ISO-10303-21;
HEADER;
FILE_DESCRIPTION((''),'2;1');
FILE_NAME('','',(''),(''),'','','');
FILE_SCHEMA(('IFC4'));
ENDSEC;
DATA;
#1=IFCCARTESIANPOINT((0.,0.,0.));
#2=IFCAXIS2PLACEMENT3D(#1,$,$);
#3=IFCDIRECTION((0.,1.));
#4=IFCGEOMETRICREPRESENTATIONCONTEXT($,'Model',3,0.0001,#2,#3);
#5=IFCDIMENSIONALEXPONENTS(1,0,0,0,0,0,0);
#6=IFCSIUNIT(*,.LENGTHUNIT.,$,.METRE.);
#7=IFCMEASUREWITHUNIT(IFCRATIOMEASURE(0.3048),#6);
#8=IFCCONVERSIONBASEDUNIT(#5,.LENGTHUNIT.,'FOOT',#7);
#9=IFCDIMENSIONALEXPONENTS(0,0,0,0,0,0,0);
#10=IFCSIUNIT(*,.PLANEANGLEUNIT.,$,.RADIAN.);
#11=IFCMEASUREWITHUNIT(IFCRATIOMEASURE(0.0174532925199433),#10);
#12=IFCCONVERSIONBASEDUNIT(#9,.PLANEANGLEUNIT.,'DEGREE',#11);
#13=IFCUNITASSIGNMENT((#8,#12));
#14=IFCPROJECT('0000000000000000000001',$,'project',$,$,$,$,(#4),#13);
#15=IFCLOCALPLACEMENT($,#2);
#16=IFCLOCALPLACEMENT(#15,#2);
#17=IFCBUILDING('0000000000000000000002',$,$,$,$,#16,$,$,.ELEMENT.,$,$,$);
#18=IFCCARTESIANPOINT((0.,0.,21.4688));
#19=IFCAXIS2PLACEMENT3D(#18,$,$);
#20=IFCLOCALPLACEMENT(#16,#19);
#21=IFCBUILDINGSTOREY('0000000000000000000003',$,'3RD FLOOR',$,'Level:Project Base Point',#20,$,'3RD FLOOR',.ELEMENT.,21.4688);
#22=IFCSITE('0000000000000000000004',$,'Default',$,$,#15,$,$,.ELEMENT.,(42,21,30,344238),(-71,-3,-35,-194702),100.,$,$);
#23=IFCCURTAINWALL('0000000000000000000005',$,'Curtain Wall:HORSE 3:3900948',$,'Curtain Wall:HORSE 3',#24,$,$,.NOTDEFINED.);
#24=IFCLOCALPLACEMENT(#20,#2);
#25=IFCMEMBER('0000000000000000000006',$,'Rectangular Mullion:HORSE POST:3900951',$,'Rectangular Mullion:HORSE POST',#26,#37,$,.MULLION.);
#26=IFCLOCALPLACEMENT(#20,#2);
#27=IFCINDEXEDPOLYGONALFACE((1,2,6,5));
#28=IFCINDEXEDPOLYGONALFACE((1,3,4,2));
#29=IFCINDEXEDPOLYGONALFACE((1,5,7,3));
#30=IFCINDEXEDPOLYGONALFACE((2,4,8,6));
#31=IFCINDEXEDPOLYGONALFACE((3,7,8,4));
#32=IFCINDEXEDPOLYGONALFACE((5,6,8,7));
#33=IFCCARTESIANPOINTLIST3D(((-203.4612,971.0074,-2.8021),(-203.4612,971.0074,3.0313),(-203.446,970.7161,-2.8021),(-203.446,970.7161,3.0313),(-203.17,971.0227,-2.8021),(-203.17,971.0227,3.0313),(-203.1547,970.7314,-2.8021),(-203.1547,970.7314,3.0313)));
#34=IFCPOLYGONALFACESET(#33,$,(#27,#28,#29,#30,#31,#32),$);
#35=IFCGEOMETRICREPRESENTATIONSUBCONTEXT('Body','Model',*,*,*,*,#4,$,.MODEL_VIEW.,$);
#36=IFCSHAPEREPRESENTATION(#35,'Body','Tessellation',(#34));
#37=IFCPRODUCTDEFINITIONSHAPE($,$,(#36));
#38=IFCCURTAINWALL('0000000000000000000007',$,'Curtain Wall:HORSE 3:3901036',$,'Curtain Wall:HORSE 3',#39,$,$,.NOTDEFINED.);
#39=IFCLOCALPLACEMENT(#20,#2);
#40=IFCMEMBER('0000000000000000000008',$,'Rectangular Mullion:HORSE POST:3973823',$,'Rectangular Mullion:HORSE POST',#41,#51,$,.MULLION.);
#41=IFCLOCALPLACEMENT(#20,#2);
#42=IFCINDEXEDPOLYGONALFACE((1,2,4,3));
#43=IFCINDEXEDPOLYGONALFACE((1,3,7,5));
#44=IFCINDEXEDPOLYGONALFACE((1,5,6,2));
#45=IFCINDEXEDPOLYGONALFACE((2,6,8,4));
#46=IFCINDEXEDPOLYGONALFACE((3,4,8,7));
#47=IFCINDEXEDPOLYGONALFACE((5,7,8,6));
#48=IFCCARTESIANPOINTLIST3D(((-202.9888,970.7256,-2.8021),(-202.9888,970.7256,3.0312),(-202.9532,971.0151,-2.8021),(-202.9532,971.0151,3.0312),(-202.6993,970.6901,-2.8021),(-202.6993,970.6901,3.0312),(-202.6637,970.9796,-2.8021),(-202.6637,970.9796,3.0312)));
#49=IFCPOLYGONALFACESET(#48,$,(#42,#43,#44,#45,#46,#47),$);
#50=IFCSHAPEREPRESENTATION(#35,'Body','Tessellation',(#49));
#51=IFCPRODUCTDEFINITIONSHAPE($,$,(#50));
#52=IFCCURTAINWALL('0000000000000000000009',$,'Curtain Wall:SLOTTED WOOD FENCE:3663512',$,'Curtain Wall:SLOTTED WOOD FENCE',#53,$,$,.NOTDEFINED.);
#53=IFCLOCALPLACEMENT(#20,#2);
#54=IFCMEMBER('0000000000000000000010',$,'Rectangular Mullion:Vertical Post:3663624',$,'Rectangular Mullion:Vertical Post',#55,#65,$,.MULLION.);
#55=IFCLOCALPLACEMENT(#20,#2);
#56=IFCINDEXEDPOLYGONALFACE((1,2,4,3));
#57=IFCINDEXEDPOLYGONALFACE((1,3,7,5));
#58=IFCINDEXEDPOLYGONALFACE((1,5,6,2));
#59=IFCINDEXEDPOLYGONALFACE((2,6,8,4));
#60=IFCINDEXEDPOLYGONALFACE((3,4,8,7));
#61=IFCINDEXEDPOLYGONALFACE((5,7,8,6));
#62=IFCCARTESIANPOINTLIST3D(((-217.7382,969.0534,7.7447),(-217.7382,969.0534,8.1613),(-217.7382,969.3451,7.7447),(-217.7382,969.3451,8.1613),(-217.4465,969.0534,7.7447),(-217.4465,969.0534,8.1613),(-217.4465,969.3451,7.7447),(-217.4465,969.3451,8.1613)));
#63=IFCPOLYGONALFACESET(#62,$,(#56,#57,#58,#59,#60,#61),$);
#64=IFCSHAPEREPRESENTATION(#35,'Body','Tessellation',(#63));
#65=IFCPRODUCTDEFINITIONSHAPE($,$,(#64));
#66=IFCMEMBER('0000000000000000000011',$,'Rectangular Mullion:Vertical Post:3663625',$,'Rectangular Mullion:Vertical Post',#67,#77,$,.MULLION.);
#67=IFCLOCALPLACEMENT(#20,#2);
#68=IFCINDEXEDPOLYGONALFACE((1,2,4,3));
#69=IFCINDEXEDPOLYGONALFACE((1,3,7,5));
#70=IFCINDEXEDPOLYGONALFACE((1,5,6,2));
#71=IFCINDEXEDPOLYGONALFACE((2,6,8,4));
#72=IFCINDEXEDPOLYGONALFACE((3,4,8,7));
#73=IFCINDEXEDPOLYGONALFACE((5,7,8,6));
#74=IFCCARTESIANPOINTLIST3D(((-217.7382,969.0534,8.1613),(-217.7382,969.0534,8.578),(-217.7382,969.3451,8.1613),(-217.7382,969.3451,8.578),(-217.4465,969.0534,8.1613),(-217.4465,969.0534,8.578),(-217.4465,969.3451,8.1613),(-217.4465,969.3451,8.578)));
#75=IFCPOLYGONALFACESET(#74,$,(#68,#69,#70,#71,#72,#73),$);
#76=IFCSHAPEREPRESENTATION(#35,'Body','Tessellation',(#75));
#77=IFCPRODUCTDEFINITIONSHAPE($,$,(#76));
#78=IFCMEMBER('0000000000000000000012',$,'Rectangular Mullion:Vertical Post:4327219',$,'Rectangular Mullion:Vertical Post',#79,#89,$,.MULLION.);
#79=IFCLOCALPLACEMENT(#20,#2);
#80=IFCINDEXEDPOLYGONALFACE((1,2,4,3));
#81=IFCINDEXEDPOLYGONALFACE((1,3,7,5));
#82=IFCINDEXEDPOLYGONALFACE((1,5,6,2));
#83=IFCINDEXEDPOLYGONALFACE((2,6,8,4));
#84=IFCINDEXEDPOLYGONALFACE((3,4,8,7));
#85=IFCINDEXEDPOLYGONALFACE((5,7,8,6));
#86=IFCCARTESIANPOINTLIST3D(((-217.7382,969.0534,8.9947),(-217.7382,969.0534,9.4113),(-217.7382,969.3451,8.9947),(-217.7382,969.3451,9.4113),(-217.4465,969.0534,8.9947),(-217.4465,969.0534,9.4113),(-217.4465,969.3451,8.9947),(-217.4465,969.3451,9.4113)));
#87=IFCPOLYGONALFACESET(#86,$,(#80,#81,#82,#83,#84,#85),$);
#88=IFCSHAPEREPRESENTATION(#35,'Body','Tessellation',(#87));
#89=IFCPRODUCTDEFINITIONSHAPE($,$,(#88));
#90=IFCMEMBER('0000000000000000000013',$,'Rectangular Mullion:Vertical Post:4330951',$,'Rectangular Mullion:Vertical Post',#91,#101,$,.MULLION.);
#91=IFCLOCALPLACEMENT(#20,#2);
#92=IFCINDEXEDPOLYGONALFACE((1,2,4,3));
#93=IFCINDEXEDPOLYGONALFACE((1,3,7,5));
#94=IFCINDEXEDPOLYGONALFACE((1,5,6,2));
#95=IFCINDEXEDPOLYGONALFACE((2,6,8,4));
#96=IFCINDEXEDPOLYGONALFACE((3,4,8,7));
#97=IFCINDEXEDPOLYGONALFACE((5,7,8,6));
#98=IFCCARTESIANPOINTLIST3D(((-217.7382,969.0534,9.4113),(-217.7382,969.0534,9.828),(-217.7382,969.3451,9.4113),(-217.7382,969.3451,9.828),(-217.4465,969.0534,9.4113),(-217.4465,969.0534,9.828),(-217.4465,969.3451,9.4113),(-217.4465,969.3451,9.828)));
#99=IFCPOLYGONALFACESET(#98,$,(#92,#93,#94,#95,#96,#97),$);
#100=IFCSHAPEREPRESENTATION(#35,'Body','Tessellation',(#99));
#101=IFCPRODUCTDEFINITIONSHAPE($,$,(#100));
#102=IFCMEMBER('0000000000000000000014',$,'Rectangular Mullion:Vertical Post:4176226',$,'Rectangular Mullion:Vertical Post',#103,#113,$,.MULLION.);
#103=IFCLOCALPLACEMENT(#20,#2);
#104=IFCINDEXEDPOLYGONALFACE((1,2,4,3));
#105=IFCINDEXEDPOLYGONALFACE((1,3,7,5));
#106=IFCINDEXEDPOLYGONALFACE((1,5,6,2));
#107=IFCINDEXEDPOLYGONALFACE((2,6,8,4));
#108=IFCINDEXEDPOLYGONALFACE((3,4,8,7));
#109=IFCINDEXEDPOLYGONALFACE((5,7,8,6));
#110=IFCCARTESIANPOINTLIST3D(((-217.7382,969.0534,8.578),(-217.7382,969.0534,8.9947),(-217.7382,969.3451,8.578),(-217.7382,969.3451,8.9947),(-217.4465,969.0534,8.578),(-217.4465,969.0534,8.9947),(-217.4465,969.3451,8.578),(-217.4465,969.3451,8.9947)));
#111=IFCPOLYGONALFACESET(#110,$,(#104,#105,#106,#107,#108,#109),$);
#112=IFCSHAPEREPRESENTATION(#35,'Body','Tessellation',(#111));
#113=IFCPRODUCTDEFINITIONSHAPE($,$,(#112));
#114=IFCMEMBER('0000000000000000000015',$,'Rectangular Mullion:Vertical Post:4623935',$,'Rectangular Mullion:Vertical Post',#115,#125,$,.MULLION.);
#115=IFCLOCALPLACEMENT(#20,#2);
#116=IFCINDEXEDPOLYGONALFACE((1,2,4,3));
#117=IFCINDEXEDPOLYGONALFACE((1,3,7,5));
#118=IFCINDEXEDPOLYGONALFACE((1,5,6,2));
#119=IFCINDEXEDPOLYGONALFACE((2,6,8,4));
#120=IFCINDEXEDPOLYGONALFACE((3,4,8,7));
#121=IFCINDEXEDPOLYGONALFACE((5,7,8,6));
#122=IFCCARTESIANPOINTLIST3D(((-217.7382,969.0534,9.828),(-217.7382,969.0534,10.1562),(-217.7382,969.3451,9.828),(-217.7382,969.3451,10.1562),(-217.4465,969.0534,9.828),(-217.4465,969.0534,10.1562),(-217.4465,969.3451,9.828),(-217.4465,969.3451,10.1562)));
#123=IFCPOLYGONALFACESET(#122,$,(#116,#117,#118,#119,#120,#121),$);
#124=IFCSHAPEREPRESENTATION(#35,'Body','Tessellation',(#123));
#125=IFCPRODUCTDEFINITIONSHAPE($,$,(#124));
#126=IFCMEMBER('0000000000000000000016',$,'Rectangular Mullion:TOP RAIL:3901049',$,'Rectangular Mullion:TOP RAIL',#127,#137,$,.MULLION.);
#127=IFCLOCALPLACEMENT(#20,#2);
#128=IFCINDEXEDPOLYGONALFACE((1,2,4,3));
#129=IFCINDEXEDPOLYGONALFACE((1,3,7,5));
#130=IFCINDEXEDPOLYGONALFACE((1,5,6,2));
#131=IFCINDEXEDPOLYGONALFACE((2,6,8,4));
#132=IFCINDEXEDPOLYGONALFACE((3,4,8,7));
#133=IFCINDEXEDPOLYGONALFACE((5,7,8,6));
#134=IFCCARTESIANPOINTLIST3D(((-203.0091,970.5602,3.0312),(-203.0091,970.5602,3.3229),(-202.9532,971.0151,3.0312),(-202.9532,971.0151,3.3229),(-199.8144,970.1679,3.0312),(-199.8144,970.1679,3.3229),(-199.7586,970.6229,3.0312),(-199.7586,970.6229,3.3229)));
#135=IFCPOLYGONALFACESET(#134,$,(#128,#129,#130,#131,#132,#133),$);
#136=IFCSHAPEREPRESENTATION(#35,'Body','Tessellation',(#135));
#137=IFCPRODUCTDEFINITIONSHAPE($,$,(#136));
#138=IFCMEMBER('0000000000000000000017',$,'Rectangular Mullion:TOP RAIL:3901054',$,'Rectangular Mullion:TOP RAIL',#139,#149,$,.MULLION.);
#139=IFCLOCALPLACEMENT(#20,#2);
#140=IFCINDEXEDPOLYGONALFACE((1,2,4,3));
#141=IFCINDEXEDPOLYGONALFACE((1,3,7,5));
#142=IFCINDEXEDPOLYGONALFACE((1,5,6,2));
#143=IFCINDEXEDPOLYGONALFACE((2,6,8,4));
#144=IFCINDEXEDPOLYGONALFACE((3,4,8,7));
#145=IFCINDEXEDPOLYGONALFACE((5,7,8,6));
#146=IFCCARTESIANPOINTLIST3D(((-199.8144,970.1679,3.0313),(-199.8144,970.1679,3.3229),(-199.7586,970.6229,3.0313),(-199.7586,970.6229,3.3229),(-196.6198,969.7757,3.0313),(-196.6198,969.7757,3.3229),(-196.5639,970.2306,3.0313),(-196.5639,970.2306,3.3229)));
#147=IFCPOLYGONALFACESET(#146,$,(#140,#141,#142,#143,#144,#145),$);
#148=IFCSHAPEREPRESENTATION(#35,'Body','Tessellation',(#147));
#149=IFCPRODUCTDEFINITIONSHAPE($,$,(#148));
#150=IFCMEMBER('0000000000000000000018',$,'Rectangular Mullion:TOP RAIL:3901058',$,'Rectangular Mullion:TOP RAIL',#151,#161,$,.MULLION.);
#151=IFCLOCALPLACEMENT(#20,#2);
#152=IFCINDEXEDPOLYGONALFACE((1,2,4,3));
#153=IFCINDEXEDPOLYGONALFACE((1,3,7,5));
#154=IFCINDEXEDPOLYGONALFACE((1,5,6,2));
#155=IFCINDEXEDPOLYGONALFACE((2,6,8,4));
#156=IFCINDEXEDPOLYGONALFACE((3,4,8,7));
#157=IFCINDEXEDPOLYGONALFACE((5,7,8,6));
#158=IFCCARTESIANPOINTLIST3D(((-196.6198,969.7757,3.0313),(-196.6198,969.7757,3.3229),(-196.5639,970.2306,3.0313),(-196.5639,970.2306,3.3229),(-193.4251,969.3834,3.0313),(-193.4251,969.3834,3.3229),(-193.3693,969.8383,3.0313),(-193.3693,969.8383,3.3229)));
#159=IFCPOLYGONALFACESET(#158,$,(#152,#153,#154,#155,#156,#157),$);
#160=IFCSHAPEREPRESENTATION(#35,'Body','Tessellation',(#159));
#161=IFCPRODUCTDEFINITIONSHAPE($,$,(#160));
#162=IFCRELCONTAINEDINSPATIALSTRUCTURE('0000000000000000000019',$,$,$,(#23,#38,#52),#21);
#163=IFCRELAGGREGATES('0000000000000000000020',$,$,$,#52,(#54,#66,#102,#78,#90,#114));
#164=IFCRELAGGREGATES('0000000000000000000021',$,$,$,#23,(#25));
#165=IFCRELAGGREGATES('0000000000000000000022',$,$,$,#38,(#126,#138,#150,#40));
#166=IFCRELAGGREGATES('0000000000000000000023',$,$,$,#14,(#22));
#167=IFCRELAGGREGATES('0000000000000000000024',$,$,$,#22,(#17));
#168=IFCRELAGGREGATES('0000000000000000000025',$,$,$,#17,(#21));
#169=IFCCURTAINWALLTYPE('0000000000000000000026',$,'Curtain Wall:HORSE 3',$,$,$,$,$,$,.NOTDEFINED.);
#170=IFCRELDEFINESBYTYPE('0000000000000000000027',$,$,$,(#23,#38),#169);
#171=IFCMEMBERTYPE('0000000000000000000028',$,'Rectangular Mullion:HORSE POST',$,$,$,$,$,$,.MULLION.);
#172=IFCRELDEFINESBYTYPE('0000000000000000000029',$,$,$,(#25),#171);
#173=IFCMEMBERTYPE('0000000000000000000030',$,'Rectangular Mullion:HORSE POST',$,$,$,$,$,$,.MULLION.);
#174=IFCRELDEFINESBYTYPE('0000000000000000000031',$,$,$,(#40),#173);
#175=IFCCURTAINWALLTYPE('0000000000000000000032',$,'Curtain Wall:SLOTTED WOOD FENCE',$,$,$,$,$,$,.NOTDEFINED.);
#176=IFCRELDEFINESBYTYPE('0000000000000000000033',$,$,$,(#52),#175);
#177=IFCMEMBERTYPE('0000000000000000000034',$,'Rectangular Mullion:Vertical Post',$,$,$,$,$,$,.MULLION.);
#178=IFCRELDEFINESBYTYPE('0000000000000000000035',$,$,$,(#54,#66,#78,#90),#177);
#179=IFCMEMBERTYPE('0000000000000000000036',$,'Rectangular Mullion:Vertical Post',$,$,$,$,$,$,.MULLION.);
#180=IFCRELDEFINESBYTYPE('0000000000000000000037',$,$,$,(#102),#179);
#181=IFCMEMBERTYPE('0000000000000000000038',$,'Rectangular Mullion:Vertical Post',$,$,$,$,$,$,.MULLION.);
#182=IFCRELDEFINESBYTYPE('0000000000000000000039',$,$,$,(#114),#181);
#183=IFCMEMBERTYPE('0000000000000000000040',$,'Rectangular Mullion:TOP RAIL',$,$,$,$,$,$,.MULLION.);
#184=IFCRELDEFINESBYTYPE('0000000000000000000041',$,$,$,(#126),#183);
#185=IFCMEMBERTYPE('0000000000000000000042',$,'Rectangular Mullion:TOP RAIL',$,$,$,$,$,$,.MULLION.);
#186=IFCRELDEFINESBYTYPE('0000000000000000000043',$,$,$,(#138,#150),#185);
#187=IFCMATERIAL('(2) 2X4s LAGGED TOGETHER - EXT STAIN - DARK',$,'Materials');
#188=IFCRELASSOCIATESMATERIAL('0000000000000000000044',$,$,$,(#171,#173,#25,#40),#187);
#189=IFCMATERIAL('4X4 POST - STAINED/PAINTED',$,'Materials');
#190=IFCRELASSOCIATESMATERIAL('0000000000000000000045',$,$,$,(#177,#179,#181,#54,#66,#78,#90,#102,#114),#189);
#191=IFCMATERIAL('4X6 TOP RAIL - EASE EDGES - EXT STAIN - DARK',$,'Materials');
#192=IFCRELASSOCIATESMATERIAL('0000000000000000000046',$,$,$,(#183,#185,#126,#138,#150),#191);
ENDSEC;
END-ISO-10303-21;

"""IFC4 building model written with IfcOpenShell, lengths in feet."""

from ifc_helpers import new_model, entity, si_unit, converted_unit, direction, frame, frame_2d, origin, origin_2d_with_axis, place, context, subcontext, project, spatial, rectangle, extrude, source, transform, mapped, material, material_profile, profile_set, profile_usage, type_object, type_shapes, element, aggregate, save


model = new_model("IFC4")

# Units and contexts
model_context = context("Model", 3, precision=0.0001, world=origin(), true_north=direction((0.0, 1.0)))
body_context = subcontext(model_context, "Body", "Model", "MODEL_VIEW")
ifc_project = project(units=[converted_unit("LENGTHUNIT", "FOOT", entity("IfcRatioMeasure", 0.3048), si_unit("LENGTHUNIT", "METRE"), dimensions=[1, 0, 0, 0, 0, 0, 0]), converted_unit("PLANEANGLEUNIT", "DEGREE", entity("IfcRatioMeasure", 0.0174532925199433), si_unit("PLANEANGLEUNIT", "RADIAN"), dimensions=[0, 0, 0, 0, 0, 0, 0])], contexts=[model_context])

# Site, building, storey
site_placement = place(None, origin())
site = spatial("IfcSite", under=ifc_project, at=site_placement, Name="Default", CompositionType="ELEMENT", RefLatitude=(42, 21, 30, 344238), RefLongitude=(-71, -3, -35, -194702), RefElevation=100.0)
building_placement = place(site_placement, origin())
building = spatial("IfcBuilding", under=site, at=building_placement, CompositionType="ELEMENT")
storey_placement = place(building_placement, frame((0.0, 0.0, 21.4688)))
storey = spatial("IfcBuildingStorey", under=building, at=storey_placement, Name="3RD FLOOR", ObjectType="Level:Project Base Point", LongName="3RD FLOOR", CompositionType="ELEMENT", Elevation=21.4688)

# Curtain walls, members
curtain_wall_type_1 = type_object("IfcCurtainWallType", Name="Curtain Wall:HORSE 3", PredefinedType="NOTDEFINED")
curtain_wall_1_placement = place(storey_placement, frame((0.0, 0.0, -21.4688)))
curtain_wall_1 = element("IfcCurtainWall", 1, at=curtain_wall_1_placement, inside=storey, type_object=curtain_wall_type_1, Name="Curtain Wall:HORSE 3:3900948", ObjectType="Curtain Wall:HORSE 3", PredefinedType="NOTDEFINED")
ifc_material_1 = material(Name="(2) 2X4s LAGGED TOGETHER - EXT STAIN - DARK", Category="Materials")
ifc_material_profile_1 = material_profile(ifc_material_1, rectangle(XDim=0.2917, YDim=0.2917, at=frame_2d((0.0, 0.0), x_axis=(1.0, 0.0))), Name="HORSE POST")
ifc_profile_set_1 = profile_set([ifc_material_profile_1], Name="HORSE POST")
ifc_profile_usage_1 = profile_usage(ifc_profile_set_1)
member_type_1 = type_object("IfcMemberType", Name="Rectangular Mullion:HORSE POST", PredefinedType="MULLION", material=ifc_profile_set_1)
shared_shape_1 = source(origin(), body_context, "Body", "SweptSolid", [
    extrude(rectangle(XDim=0.2917, YDim=0.2917, at=frame_2d((0.0, 0.0), x_axis=(1.0, 0.0))), frame((-0.1458, -0.1458, -5.8333), z_axis=(0.0, 0.0, 1.0), x_axis=(0.0, -1.0, 0.0)), (0.0, 0.0, 1.0), 5.8333),
])
type_shapes(member_type_1, [shared_shape_1])
member_1_placement = place(storey_placement, frame((-203.1547, 970.7314, -2.8021), z_axis=(0.0, 0.0, -1.0), x_axis=(0.99863, 0.052336, 0.0)))
member_1 = element("IfcMember", 2, at=member_1_placement, type_object=member_type_1, material=ifc_profile_usage_1, Name="Rectangular Mullion:HORSE POST:3900951", ObjectType="Rectangular Mullion:HORSE POST", PredefinedType="MULLION", context=body_context, shape_type="MappedRepresentation", body=[
    mapped(shared_shape_1, transform((0.0, 0.0, 0.0), scale=1.0)),
])
curtain_wall_2_placement = place(storey_placement, frame((0.0, 0.0, -21.4688)))
curtain_wall_2 = element("IfcCurtainWall", 3, at=curtain_wall_2_placement, inside=storey, type_object=curtain_wall_type_1, Name="Curtain Wall:HORSE 3:3901036", ObjectType="Curtain Wall:HORSE 3", PredefinedType="NOTDEFINED")
ifc_profile_usage_2 = profile_usage(ifc_profile_set_1)
member_type_2 = type_object("IfcMemberType", Name="Rectangular Mullion:HORSE POST", PredefinedType="MULLION", material=ifc_profile_set_1)
shared_shape_2 = source(origin(), body_context, "Body", "SweptSolid", [
    extrude(rectangle(XDim=0.2917, YDim=0.2917, at=origin_2d_with_axis()), frame((-0.1458, -0.1458, -5.8333), z_axis=(0.0, 0.0, 1.0), x_axis=(0.0, -1.0, 0.0)), (0.0, 0.0, 1.0), 5.8333),
])
type_shapes(member_type_2, [shared_shape_2])
member_2_placement = place(storey_placement, frame((-202.9888, 970.7256, 3.0312), z_axis=(0.0, 0.0, 1.0), x_axis=(-0.992546, 0.121869, 0.0)))
member_2 = element("IfcMember", 4, at=member_2_placement, type_object=member_type_2, material=ifc_profile_usage_2, Name="Rectangular Mullion:HORSE POST:3973823", ObjectType="Rectangular Mullion:HORSE POST", PredefinedType="MULLION", context=body_context, shape_type="MappedRepresentation", body=[
    mapped(shared_shape_2, transform((0.0, 0.0, 0.0), scale=1.0)),
])

# Curtain wall, members
curtain_wall_type_2 = type_object("IfcCurtainWallType", Name="Curtain Wall:SLOTTED WOOD FENCE", PredefinedType="NOTDEFINED")
curtain_wall_3_placement = place(storey_placement, frame((0.0, 0.0, -21.4688)))
curtain_wall_3 = element("IfcCurtainWall", 5, at=curtain_wall_3_placement, inside=storey, type_object=curtain_wall_type_2, Name="Curtain Wall:SLOTTED WOOD FENCE:3663512", ObjectType="Curtain Wall:SLOTTED WOOD FENCE", PredefinedType="NOTDEFINED")
ifc_material_2 = material(Name="4X4 POST - STAINED/PAINTED", Category="Materials")
ifc_material_profile_2 = material_profile(ifc_material_2, rectangle(XDim=0.2917, YDim=0.2917, at=origin_2d_with_axis()), Name="Vertical Post")
ifc_profile_set_2 = profile_set([ifc_material_profile_2], Name="Vertical Post")
ifc_profile_usage_3 = profile_usage(ifc_profile_set_2)
member_type_3 = type_object("IfcMemberType", Name="Rectangular Mullion:Vertical Post", PredefinedType="MULLION", material=ifc_profile_set_2)
shared_shape_3 = source(origin(), body_context, "Body", "SweptSolid", [
    extrude(rectangle(XDim=0.2917, YDim=0.2917, at=origin_2d_with_axis()), frame((-0.1458, -0.2083, -0.4167), z_axis=(0.0, 0.0, 1.0), x_axis=(0.0, -1.0, 0.0)), (0.0, 0.0, 1.0), 0.4167),
])
type_shapes(member_type_3, [shared_shape_3])
member_3_placement = place(storey_placement, frame((-217.8007, 969.3451, 8.1613), z_axis=(0.0, 0.0, 1.0), x_axis=(0.0, 1.0, 0.0)))
member_3 = element("IfcMember", 6, at=member_3_placement, type_object=member_type_3, material=ifc_profile_usage_3, Name="Rectangular Mullion:Vertical Post:3663624", ObjectType="Rectangular Mullion:Vertical Post", PredefinedType="MULLION", context=body_context, shape_type="MappedRepresentation", body=[
    mapped(shared_shape_3, transform((0.0, 0.0, 0.0), scale=1.0)),
])
ifc_profile_usage_4 = profile_usage(ifc_profile_set_2)
member_4_placement = place(storey_placement, frame((-217.8007, 969.3451, 8.578), z_axis=(0.0, 0.0, 1.0), x_axis=(0.0, 1.0, 0.0)))
member_4 = element("IfcMember", 7, at=member_4_placement, type_object=member_type_3, material=ifc_profile_usage_4, Name="Rectangular Mullion:Vertical Post:3663625", ObjectType="Rectangular Mullion:Vertical Post", PredefinedType="MULLION", context=body_context, shape_type="MappedRepresentation", body=[
    mapped(shared_shape_3, transform((0.0, 0.0, 0.0), scale=1.0)),
])
ifc_profile_usage_5 = profile_usage(ifc_profile_set_2)
member_5_placement = place(storey_placement, frame((-217.8007, 969.3451, 9.4113), z_axis=(0.0, 0.0, 1.0), x_axis=(0.0, 1.0, 0.0)))
member_5 = element("IfcMember", 8, at=member_5_placement, type_object=member_type_3, material=ifc_profile_usage_5, Name="Rectangular Mullion:Vertical Post:4327219", ObjectType="Rectangular Mullion:Vertical Post", PredefinedType="MULLION", context=body_context, shape_type="MappedRepresentation", body=[
    mapped(shared_shape_3, transform((0.0, 0.0, 0.0), scale=1.0)),
])
ifc_profile_usage_6 = profile_usage(ifc_profile_set_2)
member_6_placement = place(storey_placement, frame((-217.8007, 969.3451, 9.828), z_axis=(0.0, 0.0, 1.0), x_axis=(0.0, 1.0, 0.0)))
member_6 = element("IfcMember", 9, at=member_6_placement, type_object=member_type_3, material=ifc_profile_usage_6, Name="Rectangular Mullion:Vertical Post:4330951", ObjectType="Rectangular Mullion:Vertical Post", PredefinedType="MULLION", context=body_context, shape_type="MappedRepresentation", body=[
    mapped(shared_shape_3, transform((0.0, 0.0, 0.0), scale=1.0)),
])
ifc_profile_usage_7 = profile_usage(ifc_profile_set_2)
member_type_4 = type_object("IfcMemberType", Name="Rectangular Mullion:Vertical Post", PredefinedType="MULLION", material=ifc_profile_set_2)
shared_shape_4 = source(origin(), body_context, "Body", "SweptSolid", [
    extrude(rectangle(XDim=0.2917, YDim=0.2917, at=origin_2d_with_axis()), frame((-0.1458, -0.2083, -0.4167), z_axis=(0.0, 0.0, 1.0), x_axis=(0.0, -1.0, 0.0)), (0.0, 0.0, 1.0), 0.4167),
])
type_shapes(member_type_4, [shared_shape_4])
member_7_placement = place(storey_placement, frame((-217.8007, 969.3451, 8.9947), z_axis=(0.0, 0.0, 1.0), x_axis=(0.0, 1.0, 0.0)))
member_7 = element("IfcMember", 10, at=member_7_placement, type_object=member_type_4, material=ifc_profile_usage_7, Name="Rectangular Mullion:Vertical Post:4176226", ObjectType="Rectangular Mullion:Vertical Post", PredefinedType="MULLION", context=body_context, shape_type="MappedRepresentation", body=[
    mapped(shared_shape_4, transform((0.0, 0.0, 0.0), scale=1.0)),
])
ifc_profile_usage_8 = profile_usage(ifc_profile_set_2)
member_type_5 = type_object("IfcMemberType", Name="Rectangular Mullion:Vertical Post", PredefinedType="MULLION", material=ifc_profile_set_2)
shared_shape_5 = source(origin(), body_context, "Body", "SweptSolid", [
    extrude(rectangle(XDim=0.2917, YDim=0.2917, at=origin_2d_with_axis()), frame((-0.1458, -0.2083, -0.3282), z_axis=(0.0, 0.0, 1.0), x_axis=(0.0, -1.0, 0.0)), (0.0, 0.0, 1.0), 0.3282),
])
type_shapes(member_type_5, [shared_shape_5])
member_8_placement = place(storey_placement, frame((-217.8007, 969.3451, 10.1562), z_axis=(0.0, 0.0, 1.0), x_axis=(0.0, 1.0, 0.0)))
member_8 = element("IfcMember", 11, at=member_8_placement, type_object=member_type_5, material=ifc_profile_usage_8, Name="Rectangular Mullion:Vertical Post:4623935", ObjectType="Rectangular Mullion:Vertical Post", PredefinedType="MULLION", context=body_context, shape_type="MappedRepresentation", body=[
    mapped(shared_shape_5, transform((0.0, 0.0, 0.0), scale=1.0)),
])
aggregate(curtain_wall_3, [member_3, member_4, member_7, member_5, member_6, member_8])

# Members
ifc_material_3 = material(Name="4X6 TOP RAIL - EASE EDGES - EXT STAIN - DARK", Category="Materials")
ifc_material_profile_3 = material_profile(ifc_material_3, rectangle(XDim=0.4583, YDim=0.2917, at=origin_2d_with_axis()), Name="TOP RAIL")
ifc_profile_set_3 = profile_set([ifc_material_profile_3], Name="TOP RAIL")
ifc_profile_usage_9 = profile_usage(ifc_profile_set_3)
member_type_6 = type_object("IfcMemberType", Name="Rectangular Mullion:TOP RAIL", PredefinedType="MULLION", material=ifc_profile_set_3)
shared_shape_6 = source(origin(), body_context, "Body", "SweptSolid", [
    extrude(rectangle(XDim=0.4583, YDim=0.2917, at=origin_2d_with_axis()), frame((-0.1458, -0.0625, -3.2186), z_axis=(0.0, 0.0, 1.0), x_axis=(0.0, -1.0, 0.0)), (0.0, 0.0, 1.0), 3.2186),
])
type_shapes(member_type_6, [shared_shape_6])
member_9_placement = place(storey_placement, frame((-199.7941, 970.3334, 3.3229), z_axis=(0.992546, -0.121869, 0.0), x_axis=(0.0, 0.0, 1.0)))
member_9 = element("IfcMember", 12, at=member_9_placement, type_object=member_type_6, material=ifc_profile_usage_9, Name="Rectangular Mullion:TOP RAIL:3901049", ObjectType="Rectangular Mullion:TOP RAIL", PredefinedType="MULLION", context=body_context, shape_type="MappedRepresentation", body=[
    mapped(shared_shape_6, transform((0.0, 0.0, 0.0), scale=1.0)),
])
ifc_profile_usage_10 = profile_usage(ifc_profile_set_3)
member_type_7 = type_object("IfcMemberType", Name="Rectangular Mullion:TOP RAIL", PredefinedType="MULLION", material=ifc_profile_set_3)
shared_shape_7 = source(origin(), body_context, "Body", "SweptSolid", [
    extrude(rectangle(XDim=0.4583, YDim=0.2917, at=origin_2d_with_axis()), frame((-0.1458, -0.0625, -3.2186), z_axis=(0.0, 0.0, 1.0), x_axis=(0.0, -1.0, 0.0)), (0.0, 0.0, 1.0), 3.2186),
])
type_shapes(member_type_7, [shared_shape_7])
member_10_placement = place(storey_placement, frame((-196.5995, 969.9411, 3.3229), z_axis=(0.992546, -0.121869, 0.0), x_axis=(0.0, 0.0, 1.0)))
member_10 = element("IfcMember", 13, at=member_10_placement, type_object=member_type_7, material=ifc_profile_usage_10, Name="Rectangular Mullion:TOP RAIL:3901054", ObjectType="Rectangular Mullion:TOP RAIL", PredefinedType="MULLION", context=body_context, shape_type="MappedRepresentation", body=[
    mapped(shared_shape_7, transform((0.0, 0.0, 0.0), scale=1.0)),
])
ifc_profile_usage_11 = profile_usage(ifc_profile_set_3)
member_11_placement = place(storey_placement, frame((-193.4048, 969.5489, 3.3229), z_axis=(0.992546, -0.121869, 0.0), x_axis=(0.0, 0.0, 1.0)))
member_11 = element("IfcMember", 14, at=member_11_placement, type_object=member_type_7, material=ifc_profile_usage_11, Name="Rectangular Mullion:TOP RAIL:3901058", ObjectType="Rectangular Mullion:TOP RAIL", PredefinedType="MULLION", context=body_context, shape_type="MappedRepresentation", body=[
    mapped(shared_shape_7, transform((0.0, 0.0, 0.0), scale=1.0)),
])

aggregate(curtain_wall_1, [member_1])
aggregate(curtain_wall_2, [member_9, member_10, member_11, member_2])

save(model, "model.ifc")
